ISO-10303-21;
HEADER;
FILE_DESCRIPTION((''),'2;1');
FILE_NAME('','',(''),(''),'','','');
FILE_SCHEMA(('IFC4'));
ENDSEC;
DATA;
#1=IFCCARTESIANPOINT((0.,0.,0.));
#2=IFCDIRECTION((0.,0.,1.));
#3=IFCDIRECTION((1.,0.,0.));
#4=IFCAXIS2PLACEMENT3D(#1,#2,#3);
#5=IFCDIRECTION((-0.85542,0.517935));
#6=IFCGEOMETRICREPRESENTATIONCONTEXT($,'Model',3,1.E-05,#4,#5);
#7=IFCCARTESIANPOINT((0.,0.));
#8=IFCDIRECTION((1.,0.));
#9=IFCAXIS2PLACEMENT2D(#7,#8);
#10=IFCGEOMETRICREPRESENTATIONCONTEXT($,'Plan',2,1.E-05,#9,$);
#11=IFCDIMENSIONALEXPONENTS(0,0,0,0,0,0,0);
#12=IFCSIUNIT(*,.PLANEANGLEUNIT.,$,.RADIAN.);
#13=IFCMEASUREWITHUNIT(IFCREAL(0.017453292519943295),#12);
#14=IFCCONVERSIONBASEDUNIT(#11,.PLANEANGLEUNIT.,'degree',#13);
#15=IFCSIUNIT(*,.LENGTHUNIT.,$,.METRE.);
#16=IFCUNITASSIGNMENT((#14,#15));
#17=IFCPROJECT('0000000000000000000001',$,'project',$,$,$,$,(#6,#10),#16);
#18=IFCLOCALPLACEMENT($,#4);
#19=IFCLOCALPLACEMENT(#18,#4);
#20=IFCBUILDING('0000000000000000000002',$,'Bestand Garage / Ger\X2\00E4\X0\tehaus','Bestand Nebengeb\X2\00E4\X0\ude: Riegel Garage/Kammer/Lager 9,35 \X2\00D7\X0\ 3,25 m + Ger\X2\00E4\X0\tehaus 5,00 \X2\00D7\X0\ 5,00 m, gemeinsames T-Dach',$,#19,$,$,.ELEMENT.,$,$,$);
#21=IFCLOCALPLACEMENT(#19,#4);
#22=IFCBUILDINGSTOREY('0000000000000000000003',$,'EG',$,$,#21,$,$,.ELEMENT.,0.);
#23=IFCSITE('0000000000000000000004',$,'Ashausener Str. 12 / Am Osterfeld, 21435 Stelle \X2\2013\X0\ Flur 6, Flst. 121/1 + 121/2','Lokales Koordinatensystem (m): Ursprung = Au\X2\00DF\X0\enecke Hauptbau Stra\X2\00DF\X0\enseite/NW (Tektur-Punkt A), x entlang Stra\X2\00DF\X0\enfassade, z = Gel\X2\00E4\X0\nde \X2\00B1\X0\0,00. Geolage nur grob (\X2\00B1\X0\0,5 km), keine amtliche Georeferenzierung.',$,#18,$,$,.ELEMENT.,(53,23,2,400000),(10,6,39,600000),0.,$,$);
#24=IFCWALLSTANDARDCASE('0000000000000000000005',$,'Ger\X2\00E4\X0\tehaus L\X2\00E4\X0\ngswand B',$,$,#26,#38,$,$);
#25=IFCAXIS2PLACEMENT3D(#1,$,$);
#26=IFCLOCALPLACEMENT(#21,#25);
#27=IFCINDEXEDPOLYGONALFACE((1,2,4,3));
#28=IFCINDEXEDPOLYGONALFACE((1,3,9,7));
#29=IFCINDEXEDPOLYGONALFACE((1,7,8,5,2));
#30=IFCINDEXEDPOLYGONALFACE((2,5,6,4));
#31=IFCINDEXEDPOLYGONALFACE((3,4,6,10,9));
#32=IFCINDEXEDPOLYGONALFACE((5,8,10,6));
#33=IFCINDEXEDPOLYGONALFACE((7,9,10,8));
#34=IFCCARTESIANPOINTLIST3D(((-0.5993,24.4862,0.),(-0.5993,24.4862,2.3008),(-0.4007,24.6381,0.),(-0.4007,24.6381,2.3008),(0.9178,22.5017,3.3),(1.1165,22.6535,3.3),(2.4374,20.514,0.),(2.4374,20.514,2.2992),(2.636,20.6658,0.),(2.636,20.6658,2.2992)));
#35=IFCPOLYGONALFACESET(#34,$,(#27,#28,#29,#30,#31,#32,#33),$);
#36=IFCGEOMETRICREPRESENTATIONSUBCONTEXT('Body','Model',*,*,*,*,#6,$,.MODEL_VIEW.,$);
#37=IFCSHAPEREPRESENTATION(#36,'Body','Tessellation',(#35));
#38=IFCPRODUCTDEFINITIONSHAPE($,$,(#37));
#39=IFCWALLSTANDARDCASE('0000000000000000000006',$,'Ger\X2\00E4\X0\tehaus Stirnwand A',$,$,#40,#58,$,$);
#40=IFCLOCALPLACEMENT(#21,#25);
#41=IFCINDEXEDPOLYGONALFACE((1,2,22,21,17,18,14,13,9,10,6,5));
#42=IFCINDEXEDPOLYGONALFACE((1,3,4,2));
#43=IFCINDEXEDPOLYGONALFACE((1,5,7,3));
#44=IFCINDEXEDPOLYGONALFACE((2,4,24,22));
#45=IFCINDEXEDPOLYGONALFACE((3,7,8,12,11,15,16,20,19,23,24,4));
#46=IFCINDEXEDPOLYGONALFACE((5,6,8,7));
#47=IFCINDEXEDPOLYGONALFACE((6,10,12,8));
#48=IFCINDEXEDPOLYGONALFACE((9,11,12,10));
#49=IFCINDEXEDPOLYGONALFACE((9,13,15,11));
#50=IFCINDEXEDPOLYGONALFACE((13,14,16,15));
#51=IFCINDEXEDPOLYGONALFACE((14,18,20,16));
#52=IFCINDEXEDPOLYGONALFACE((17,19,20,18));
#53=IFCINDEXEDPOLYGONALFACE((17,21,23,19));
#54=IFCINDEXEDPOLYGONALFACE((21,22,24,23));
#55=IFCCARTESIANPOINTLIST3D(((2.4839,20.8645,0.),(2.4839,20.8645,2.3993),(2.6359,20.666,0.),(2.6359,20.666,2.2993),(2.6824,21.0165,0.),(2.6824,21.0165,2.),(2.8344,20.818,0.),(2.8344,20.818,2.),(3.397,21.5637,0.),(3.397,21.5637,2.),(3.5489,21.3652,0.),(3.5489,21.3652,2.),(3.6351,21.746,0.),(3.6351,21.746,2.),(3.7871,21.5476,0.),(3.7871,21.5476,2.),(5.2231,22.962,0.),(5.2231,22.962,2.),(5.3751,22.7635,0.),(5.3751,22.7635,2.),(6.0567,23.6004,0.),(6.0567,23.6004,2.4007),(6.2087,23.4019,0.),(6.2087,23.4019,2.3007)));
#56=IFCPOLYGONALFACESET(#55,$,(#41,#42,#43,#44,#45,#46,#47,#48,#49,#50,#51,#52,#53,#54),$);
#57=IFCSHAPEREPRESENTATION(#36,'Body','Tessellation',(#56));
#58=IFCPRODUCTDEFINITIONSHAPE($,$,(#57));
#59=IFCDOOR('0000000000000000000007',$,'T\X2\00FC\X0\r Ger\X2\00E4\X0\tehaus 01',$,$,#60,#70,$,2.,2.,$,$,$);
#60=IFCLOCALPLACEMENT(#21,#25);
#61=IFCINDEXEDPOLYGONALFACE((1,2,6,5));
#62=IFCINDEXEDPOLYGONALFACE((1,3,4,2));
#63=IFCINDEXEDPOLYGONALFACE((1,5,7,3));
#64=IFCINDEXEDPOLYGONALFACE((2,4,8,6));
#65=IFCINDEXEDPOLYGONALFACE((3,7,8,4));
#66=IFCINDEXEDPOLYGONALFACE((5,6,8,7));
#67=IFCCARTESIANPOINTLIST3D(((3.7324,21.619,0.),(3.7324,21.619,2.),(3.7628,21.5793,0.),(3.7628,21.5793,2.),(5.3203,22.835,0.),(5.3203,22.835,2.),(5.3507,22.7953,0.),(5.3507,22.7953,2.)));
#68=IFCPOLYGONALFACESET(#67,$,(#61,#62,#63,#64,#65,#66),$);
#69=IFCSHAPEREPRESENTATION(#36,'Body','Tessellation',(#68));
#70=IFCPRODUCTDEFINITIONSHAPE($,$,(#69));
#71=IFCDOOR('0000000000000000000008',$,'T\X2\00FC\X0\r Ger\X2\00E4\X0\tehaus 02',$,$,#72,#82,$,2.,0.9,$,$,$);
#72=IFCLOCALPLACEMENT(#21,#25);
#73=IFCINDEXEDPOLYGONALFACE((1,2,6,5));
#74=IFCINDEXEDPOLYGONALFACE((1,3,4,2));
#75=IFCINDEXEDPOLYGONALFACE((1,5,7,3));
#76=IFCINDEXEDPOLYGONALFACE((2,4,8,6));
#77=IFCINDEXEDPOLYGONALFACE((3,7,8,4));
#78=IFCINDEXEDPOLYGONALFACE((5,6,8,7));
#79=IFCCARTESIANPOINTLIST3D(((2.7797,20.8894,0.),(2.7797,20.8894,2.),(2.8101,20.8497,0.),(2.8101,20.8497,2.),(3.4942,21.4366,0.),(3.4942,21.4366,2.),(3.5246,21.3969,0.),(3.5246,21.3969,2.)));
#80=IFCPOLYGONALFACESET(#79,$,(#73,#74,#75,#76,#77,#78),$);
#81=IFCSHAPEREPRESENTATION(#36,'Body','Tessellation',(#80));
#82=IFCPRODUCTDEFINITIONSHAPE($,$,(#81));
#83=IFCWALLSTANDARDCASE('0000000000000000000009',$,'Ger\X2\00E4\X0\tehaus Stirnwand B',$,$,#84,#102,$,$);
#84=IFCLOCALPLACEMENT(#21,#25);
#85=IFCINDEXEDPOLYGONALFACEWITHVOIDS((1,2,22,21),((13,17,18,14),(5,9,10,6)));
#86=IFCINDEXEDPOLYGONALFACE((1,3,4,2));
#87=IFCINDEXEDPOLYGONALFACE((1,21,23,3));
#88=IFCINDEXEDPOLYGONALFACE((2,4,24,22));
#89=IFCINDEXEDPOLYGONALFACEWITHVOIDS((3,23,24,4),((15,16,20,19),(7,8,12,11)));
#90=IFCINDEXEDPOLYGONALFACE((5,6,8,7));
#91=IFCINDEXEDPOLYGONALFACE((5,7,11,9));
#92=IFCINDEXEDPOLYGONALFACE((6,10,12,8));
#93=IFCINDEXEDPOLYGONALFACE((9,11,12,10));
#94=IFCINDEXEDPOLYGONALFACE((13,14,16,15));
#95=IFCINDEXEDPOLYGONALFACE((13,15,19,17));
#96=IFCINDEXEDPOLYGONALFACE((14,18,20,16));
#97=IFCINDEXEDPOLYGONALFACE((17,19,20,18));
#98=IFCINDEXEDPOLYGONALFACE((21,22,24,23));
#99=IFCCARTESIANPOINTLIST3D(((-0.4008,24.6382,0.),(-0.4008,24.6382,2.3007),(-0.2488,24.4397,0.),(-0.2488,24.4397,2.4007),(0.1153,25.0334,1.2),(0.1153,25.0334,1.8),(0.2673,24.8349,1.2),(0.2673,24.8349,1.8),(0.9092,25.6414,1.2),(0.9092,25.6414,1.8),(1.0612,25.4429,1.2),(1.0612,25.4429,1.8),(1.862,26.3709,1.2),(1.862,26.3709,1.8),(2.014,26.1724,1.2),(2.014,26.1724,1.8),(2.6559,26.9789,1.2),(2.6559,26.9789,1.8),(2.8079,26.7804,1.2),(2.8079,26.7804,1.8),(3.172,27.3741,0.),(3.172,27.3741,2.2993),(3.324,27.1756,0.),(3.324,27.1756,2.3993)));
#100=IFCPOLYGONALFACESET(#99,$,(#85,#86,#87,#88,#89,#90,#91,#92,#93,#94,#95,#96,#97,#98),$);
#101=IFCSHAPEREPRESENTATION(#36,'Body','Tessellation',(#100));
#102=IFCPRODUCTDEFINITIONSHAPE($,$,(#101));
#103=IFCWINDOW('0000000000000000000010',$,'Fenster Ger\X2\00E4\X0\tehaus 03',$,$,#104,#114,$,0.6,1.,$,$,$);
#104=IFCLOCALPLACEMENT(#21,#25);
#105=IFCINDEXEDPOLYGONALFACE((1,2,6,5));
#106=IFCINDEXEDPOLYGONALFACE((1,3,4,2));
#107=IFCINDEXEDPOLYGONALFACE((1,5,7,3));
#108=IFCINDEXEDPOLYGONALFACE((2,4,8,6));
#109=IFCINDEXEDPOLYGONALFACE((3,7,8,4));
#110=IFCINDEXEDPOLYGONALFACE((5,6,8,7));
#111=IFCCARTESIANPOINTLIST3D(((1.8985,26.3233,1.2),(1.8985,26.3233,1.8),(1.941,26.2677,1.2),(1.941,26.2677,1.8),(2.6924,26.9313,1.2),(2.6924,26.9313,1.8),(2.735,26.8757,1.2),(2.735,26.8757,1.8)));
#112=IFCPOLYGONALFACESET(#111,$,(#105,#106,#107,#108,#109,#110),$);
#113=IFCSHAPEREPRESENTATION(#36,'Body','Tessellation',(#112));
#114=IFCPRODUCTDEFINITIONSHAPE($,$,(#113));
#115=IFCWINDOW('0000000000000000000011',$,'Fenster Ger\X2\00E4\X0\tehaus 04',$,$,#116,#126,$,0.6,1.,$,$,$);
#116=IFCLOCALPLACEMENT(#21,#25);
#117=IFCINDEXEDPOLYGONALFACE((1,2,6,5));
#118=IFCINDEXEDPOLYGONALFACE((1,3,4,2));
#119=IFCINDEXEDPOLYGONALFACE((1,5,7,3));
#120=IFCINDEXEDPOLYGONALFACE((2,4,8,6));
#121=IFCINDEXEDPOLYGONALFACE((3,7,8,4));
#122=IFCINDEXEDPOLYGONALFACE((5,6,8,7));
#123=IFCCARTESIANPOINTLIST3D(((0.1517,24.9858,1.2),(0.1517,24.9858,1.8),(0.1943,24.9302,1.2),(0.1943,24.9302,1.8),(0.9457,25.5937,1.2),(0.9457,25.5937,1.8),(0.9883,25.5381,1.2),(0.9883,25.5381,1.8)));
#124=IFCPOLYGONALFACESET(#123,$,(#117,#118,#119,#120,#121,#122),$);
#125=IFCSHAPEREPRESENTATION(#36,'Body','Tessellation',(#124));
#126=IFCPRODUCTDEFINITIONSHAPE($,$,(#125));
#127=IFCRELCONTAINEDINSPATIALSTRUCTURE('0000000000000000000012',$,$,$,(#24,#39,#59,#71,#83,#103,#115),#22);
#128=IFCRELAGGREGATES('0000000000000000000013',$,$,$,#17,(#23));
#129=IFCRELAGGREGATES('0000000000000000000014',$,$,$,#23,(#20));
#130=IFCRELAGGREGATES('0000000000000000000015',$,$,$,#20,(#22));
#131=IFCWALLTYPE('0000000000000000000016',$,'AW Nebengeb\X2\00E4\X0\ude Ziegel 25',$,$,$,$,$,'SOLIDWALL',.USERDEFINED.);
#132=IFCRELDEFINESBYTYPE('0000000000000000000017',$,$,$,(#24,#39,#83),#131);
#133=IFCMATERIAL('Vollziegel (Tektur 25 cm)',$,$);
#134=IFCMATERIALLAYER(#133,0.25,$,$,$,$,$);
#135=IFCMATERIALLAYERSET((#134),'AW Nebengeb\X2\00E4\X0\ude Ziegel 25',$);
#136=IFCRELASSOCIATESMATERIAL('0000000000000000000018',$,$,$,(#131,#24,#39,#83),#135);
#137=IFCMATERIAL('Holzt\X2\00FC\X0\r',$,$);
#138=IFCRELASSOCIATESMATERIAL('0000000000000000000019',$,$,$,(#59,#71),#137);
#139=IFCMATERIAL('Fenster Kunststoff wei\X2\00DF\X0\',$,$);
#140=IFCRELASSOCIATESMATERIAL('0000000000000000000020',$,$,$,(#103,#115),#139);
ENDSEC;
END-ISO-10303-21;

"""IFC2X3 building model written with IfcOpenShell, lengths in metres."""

from ifc_helpers import new_model, entity, si_unit, converted_unit, direction, frame, origin_with_axes, origin_2d_with_axis, place, context, subcontext, project, spatial, polyline, outline, extrude, clip, halfspace, material, layer, layer_set, layer_usage, type_object, element, fill, save


model = new_model("IFC2X3")

# Units and contexts
model_context = context("Model", 3, precision=1e-05, world=origin_with_axes(), true_north=direction((-0.85542, 0.517935)))
plan_context = context("Plan", 2, precision=1e-05, world=origin_2d_with_axis())
body_context = subcontext(model_context, "Body", "Model", "MODEL_VIEW")
ifc_project = project(units=[converted_unit("PLANEANGLEUNIT", "degree", entity("IfcReal", 0.017453292519943295), si_unit("PLANEANGLEUNIT", "RADIAN"), dimensions=[0, 0, 0, 0, 0, 0, 0]), si_unit("LENGTHUNIT", "METRE")], contexts=[model_context, plan_context])

# Site, building, storey
site_placement = place(None, origin_with_axes())
site = spatial("IfcSite", under=ifc_project, at=site_placement, Name="Ashausener Str. 12 / Am Osterfeld, 21435 Stelle – Flur 6, Flst. 121/1 + 121/2", Description="Lokales Koordinatensystem (m): Ursprung = Außenecke Hauptbau Straßenseite/NW (Tektur-Punkt A), x entlang Straßenfassade, z = Gelände ±0,00. Geolage nur grob (±0,5 km), keine amtliche Georeferenzierung.", CompositionType="ELEMENT", RefLatitude=(53, 23, 2, 400000), RefLongitude=(10, 6, 39, 600000), RefElevation=0.0)
building_placement = place(site_placement, origin_with_axes())
building = spatial("IfcBuilding", under=site, at=building_placement, Name="Bestand Garage / Gerätehaus", Description="Bestand Nebengebäude: Riegel Garage/Kammer/Lager 9,35 × 3,25 m + Gerätehaus 5,00 × 5,00 m, gemeinsames T-Dach", CompositionType="ELEMENT")
storey_placement = place(building_placement, origin_with_axes())
storey = spatial("IfcBuildingStorey", under=building, at=storey_placement, Name="EG", CompositionType="ELEMENT", Elevation=0.0)

# Shared definitions
ifc_material_1 = material(Name="Vollziegel (Tektur 25 cm)")
ifc_layer_1 = layer(ifc_material_1, 0.25)
ifc_layer_set_1 = layer_set([ifc_layer_1], Name="AW Nebengebäude Ziegel 25")
wall_type = type_object("IfcWallType", Name="AW Nebengebäude Ziegel 25", ElementType="SOLIDWALL", PredefinedType="USERDEFINED", material=ifc_layer_set_1)

# Wall
ifc_layer_usage_1 = layer_usage(ifc_layer_set_1, "AXIS2", "POSITIVE", 0.0)
wall_1_placement = place(storey_placement, frame((-0.5993, 24.4862, 0.0), z_axis=(0.0, 0.0, 1.0), x_axis=(0.607339, -0.794443, 0.0)))
element("IfcWallStandardCase", 1, at=wall_1_placement, inside=storey, type_object=wall_type, material=ifc_layer_usage_1, Name="Gerätehaus Längswand B", context=body_context, shape_type="Clipping", body=[
    clip(clip(extrude(outline(polyline([(0.0, 0.0), (0.0, 0.25), (5.0, 0.25), (5.0, 0.0), (0.0, 0.0)])), origin_with_axes(), (0.0, 0.0, 1.0), 6.0), halfspace(frame((-0.002, 2.5, 2.3), z_axis=(-0.37139, 0.0, 0.92848), x_axis=(0.0, 1.0, 0.0)), False)), halfspace(frame((4.998, 2.5, 2.3), z_axis=(0.37139, 0.0, 0.92848), x_axis=(0.0, -1.0, 0.0)), False)),
])

# Wall, openings, doors
ifc_layer_usage_2 = layer_usage(ifc_layer_set_1, "AXIS2", "POSITIVE", 0.0)
wall_2_placement = place(storey_placement, frame((2.6359, 20.666, 0.0), z_axis=(0.0, 0.0, 1.0), x_axis=(0.79396, 0.60797, 0.0)))
wall_2 = element("IfcWallStandardCase", 2, at=wall_2_placement, inside=storey, type_object=wall_type, material=ifc_layer_usage_2, Name="Gerätehaus Stirnwand A", context=body_context, shape_type="Clipping", body=[
    clip(clip(extrude(outline(polyline([(0.0, 0.0), (0.0, 0.25), (4.5, 0.25), (4.5, 0.0), (0.0, 0.0)])), origin_with_axes(), (0.0, 0.0, 1.0), 6.0), halfspace(frame((2.254, 5.0, 2.3), z_axis=(0.000295, 0.37139, 0.92848), x_axis=(1.0, -0.000795, 0.0)), False)), halfspace(frame((2.25, 0.0, 2.3), z_axis=(-0.000295, -0.37139, 0.92848), x_axis=(-1.0, 0.000795, 0.0)), False)),
])
opening_1_placement = place(wall_2_placement, frame((1.45, -0.1, 0.0), z_axis=(0.0, 0.0, 1.0), x_axis=(1.0, 0.0, 0.0)))
opening_1 = element("IfcOpeningElement", 3, at=opening_1_placement, cuts=wall_2, context=body_context, shape_type="SweptSolid", body=[
    extrude(outline(polyline([(0.0, 0.0), (0.0, 0.45), (2.0, 0.45), (2.0, 0.0), (0.0, 0.0)])), origin_with_axes(), (0.0, 0.0, 1.0), 2.0),
])
opening_2_placement = place(wall_2_placement, frame((0.25, -0.1, 0.0), z_axis=(0.0, 0.0, 1.0), x_axis=(1.0, 0.0, 0.0)))
opening_2 = element("IfcOpeningElement", 4, at=opening_2_placement, cuts=wall_2, context=body_context, shape_type="SweptSolid", body=[
    extrude(outline(polyline([(0.0, 0.0), (0.0, 0.45), (0.9, 0.45), (0.9, 0.0), (0.0, 0.0)])), origin_with_axes(), (0.0, 0.0, 1.0), 2.0),
])
ifc_material_2 = material(Name="Holztür")
door_1_placement = place(storey_placement, frame((3.7628, 21.5793, 0.0), z_axis=(0.0, 0.0, 1.0), x_axis=(0.79396, 0.60797, 0.0)))
door_1 = element("IfcDoor", 5, at=door_1_placement, inside=storey, material=ifc_material_2, Name="Tür Gerätehaus 01", OverallHeight=2.0, OverallWidth=2.0, context=body_context, shape_type="SweptSolid", body=[
    extrude(outline(polyline([(0.0, 0.0), (0.0, 0.05), (2.0, 0.05), (2.0, 0.0), (0.0, 0.0)])), origin_with_axes(), (0.0, 0.0, 1.0), 2.0),
])
fill(opening_1, door_1)
door_2_placement = place(storey_placement, frame((2.8101, 20.8497, 0.0), z_axis=(0.0, 0.0, 1.0), x_axis=(0.79396, 0.60797, 0.0)))
door_2 = element("IfcDoor", 6, at=door_2_placement, inside=storey, material=ifc_material_2, Name="Tür Gerätehaus 02", OverallHeight=2.0, OverallWidth=0.9, context=body_context, shape_type="SweptSolid", body=[
    extrude(outline(polyline([(0.0, 0.0), (0.0, 0.05), (0.9, 0.05), (0.9, 0.0), (0.0, 0.0)])), origin_with_axes(), (0.0, 0.0, 1.0), 2.0),
])
fill(opening_2, door_2)

# Wall, openings, windows
ifc_layer_usage_3 = layer_usage(ifc_layer_set_1, "AXIS2", "POSITIVE", 0.0)
wall_3_placement = place(storey_placement, frame((3.172, 27.3741, 0.0), z_axis=(0.0, 0.0, 1.0), x_axis=(-0.79396, -0.60797, 0.0)))
wall_3 = element("IfcWallStandardCase", 7, at=wall_3_placement, inside=storey, type_object=wall_type, material=ifc_layer_usage_3, Name="Gerätehaus Stirnwand B", context=body_context, shape_type="Clipping", body=[
    clip(clip(extrude(outline(polyline([(0.0, 0.0), (0.0, 0.25), (4.5, 0.25), (4.5, 0.0), (0.0, 0.0)])), origin_with_axes(), (0.0, 0.0, 1.0), 6.0), halfspace(frame((2.25, 0.0, 2.3), z_axis=(-0.000295, -0.37139, 0.92848), x_axis=(-1.0, 0.000795, 0.0)), False)), halfspace(frame((2.254, 5.0, 2.3), z_axis=(0.000295, 0.37139, 0.92848), x_axis=(1.0, -0.000795, 0.0)), False)),
])
opening_3_placement = place(wall_3_placement, frame((0.65, -0.1, 1.2), z_axis=(0.0, 0.0, 1.0), x_axis=(1.0, 0.0, 0.0)))
opening_3 = element("IfcOpeningElement", 8, at=opening_3_placement, cuts=wall_3, context=body_context, shape_type="SweptSolid", body=[
    extrude(outline(polyline([(0.0, 0.0), (0.0, 0.45), (1.0, 0.45), (1.0, 0.0), (0.0, 0.0)])), origin_with_axes(), (0.0, 0.0, 1.0), 0.6),
])
opening_4_placement = place(wall_3_placement, frame((2.85, -0.1, 1.2), z_axis=(0.0, 0.0, 1.0), x_axis=(1.0, 0.0, 0.0)))
opening_4 = element("IfcOpeningElement", 9, at=opening_4_placement, cuts=wall_3, context=body_context, shape_type="SweptSolid", body=[
    extrude(outline(polyline([(0.0, 0.0), (0.0, 0.45), (1.0, 0.45), (1.0, 0.0), (0.0, 0.0)])), origin_with_axes(), (0.0, 0.0, 1.0), 0.6),
])
ifc_material_3 = material(Name="Fenster Kunststoff weiß")
window_1_placement = place(storey_placement, frame((2.6924, 26.9313, 1.2), z_axis=(0.0, 0.0, 1.0), x_axis=(-0.79396, -0.60797, 0.0)))
window_1 = element("IfcWindow", 10, at=window_1_placement, inside=storey, material=ifc_material_3, Name="Fenster Gerätehaus 03", OverallHeight=0.6, OverallWidth=1.0, context=body_context, shape_type="SweptSolid", body=[
    extrude(outline(polyline([(0.0, 0.0), (0.0, 0.07), (1.0, 0.07), (1.0, 0.0), (0.0, 0.0)])), origin_with_axes(), (0.0, 0.0, 1.0), 0.6),
])
fill(opening_3, window_1)
window_2_placement = place(storey_placement, frame((0.9457, 25.5937, 1.2), z_axis=(0.0, 0.0, 1.0), x_axis=(-0.79396, -0.60797, 0.0)))
window_2 = element("IfcWindow", 11, at=window_2_placement, inside=storey, material=ifc_material_3, Name="Fenster Gerätehaus 04", OverallHeight=0.6, OverallWidth=1.0, context=body_context, shape_type="SweptSolid", body=[
    extrude(outline(polyline([(0.0, 0.0), (0.0, 0.07), (1.0, 0.07), (1.0, 0.0), (0.0, 0.0)])), origin_with_axes(), (0.0, 0.0, 1.0), 0.6),
])
fill(opening_4, window_2)

save(model, "model.ifc")
